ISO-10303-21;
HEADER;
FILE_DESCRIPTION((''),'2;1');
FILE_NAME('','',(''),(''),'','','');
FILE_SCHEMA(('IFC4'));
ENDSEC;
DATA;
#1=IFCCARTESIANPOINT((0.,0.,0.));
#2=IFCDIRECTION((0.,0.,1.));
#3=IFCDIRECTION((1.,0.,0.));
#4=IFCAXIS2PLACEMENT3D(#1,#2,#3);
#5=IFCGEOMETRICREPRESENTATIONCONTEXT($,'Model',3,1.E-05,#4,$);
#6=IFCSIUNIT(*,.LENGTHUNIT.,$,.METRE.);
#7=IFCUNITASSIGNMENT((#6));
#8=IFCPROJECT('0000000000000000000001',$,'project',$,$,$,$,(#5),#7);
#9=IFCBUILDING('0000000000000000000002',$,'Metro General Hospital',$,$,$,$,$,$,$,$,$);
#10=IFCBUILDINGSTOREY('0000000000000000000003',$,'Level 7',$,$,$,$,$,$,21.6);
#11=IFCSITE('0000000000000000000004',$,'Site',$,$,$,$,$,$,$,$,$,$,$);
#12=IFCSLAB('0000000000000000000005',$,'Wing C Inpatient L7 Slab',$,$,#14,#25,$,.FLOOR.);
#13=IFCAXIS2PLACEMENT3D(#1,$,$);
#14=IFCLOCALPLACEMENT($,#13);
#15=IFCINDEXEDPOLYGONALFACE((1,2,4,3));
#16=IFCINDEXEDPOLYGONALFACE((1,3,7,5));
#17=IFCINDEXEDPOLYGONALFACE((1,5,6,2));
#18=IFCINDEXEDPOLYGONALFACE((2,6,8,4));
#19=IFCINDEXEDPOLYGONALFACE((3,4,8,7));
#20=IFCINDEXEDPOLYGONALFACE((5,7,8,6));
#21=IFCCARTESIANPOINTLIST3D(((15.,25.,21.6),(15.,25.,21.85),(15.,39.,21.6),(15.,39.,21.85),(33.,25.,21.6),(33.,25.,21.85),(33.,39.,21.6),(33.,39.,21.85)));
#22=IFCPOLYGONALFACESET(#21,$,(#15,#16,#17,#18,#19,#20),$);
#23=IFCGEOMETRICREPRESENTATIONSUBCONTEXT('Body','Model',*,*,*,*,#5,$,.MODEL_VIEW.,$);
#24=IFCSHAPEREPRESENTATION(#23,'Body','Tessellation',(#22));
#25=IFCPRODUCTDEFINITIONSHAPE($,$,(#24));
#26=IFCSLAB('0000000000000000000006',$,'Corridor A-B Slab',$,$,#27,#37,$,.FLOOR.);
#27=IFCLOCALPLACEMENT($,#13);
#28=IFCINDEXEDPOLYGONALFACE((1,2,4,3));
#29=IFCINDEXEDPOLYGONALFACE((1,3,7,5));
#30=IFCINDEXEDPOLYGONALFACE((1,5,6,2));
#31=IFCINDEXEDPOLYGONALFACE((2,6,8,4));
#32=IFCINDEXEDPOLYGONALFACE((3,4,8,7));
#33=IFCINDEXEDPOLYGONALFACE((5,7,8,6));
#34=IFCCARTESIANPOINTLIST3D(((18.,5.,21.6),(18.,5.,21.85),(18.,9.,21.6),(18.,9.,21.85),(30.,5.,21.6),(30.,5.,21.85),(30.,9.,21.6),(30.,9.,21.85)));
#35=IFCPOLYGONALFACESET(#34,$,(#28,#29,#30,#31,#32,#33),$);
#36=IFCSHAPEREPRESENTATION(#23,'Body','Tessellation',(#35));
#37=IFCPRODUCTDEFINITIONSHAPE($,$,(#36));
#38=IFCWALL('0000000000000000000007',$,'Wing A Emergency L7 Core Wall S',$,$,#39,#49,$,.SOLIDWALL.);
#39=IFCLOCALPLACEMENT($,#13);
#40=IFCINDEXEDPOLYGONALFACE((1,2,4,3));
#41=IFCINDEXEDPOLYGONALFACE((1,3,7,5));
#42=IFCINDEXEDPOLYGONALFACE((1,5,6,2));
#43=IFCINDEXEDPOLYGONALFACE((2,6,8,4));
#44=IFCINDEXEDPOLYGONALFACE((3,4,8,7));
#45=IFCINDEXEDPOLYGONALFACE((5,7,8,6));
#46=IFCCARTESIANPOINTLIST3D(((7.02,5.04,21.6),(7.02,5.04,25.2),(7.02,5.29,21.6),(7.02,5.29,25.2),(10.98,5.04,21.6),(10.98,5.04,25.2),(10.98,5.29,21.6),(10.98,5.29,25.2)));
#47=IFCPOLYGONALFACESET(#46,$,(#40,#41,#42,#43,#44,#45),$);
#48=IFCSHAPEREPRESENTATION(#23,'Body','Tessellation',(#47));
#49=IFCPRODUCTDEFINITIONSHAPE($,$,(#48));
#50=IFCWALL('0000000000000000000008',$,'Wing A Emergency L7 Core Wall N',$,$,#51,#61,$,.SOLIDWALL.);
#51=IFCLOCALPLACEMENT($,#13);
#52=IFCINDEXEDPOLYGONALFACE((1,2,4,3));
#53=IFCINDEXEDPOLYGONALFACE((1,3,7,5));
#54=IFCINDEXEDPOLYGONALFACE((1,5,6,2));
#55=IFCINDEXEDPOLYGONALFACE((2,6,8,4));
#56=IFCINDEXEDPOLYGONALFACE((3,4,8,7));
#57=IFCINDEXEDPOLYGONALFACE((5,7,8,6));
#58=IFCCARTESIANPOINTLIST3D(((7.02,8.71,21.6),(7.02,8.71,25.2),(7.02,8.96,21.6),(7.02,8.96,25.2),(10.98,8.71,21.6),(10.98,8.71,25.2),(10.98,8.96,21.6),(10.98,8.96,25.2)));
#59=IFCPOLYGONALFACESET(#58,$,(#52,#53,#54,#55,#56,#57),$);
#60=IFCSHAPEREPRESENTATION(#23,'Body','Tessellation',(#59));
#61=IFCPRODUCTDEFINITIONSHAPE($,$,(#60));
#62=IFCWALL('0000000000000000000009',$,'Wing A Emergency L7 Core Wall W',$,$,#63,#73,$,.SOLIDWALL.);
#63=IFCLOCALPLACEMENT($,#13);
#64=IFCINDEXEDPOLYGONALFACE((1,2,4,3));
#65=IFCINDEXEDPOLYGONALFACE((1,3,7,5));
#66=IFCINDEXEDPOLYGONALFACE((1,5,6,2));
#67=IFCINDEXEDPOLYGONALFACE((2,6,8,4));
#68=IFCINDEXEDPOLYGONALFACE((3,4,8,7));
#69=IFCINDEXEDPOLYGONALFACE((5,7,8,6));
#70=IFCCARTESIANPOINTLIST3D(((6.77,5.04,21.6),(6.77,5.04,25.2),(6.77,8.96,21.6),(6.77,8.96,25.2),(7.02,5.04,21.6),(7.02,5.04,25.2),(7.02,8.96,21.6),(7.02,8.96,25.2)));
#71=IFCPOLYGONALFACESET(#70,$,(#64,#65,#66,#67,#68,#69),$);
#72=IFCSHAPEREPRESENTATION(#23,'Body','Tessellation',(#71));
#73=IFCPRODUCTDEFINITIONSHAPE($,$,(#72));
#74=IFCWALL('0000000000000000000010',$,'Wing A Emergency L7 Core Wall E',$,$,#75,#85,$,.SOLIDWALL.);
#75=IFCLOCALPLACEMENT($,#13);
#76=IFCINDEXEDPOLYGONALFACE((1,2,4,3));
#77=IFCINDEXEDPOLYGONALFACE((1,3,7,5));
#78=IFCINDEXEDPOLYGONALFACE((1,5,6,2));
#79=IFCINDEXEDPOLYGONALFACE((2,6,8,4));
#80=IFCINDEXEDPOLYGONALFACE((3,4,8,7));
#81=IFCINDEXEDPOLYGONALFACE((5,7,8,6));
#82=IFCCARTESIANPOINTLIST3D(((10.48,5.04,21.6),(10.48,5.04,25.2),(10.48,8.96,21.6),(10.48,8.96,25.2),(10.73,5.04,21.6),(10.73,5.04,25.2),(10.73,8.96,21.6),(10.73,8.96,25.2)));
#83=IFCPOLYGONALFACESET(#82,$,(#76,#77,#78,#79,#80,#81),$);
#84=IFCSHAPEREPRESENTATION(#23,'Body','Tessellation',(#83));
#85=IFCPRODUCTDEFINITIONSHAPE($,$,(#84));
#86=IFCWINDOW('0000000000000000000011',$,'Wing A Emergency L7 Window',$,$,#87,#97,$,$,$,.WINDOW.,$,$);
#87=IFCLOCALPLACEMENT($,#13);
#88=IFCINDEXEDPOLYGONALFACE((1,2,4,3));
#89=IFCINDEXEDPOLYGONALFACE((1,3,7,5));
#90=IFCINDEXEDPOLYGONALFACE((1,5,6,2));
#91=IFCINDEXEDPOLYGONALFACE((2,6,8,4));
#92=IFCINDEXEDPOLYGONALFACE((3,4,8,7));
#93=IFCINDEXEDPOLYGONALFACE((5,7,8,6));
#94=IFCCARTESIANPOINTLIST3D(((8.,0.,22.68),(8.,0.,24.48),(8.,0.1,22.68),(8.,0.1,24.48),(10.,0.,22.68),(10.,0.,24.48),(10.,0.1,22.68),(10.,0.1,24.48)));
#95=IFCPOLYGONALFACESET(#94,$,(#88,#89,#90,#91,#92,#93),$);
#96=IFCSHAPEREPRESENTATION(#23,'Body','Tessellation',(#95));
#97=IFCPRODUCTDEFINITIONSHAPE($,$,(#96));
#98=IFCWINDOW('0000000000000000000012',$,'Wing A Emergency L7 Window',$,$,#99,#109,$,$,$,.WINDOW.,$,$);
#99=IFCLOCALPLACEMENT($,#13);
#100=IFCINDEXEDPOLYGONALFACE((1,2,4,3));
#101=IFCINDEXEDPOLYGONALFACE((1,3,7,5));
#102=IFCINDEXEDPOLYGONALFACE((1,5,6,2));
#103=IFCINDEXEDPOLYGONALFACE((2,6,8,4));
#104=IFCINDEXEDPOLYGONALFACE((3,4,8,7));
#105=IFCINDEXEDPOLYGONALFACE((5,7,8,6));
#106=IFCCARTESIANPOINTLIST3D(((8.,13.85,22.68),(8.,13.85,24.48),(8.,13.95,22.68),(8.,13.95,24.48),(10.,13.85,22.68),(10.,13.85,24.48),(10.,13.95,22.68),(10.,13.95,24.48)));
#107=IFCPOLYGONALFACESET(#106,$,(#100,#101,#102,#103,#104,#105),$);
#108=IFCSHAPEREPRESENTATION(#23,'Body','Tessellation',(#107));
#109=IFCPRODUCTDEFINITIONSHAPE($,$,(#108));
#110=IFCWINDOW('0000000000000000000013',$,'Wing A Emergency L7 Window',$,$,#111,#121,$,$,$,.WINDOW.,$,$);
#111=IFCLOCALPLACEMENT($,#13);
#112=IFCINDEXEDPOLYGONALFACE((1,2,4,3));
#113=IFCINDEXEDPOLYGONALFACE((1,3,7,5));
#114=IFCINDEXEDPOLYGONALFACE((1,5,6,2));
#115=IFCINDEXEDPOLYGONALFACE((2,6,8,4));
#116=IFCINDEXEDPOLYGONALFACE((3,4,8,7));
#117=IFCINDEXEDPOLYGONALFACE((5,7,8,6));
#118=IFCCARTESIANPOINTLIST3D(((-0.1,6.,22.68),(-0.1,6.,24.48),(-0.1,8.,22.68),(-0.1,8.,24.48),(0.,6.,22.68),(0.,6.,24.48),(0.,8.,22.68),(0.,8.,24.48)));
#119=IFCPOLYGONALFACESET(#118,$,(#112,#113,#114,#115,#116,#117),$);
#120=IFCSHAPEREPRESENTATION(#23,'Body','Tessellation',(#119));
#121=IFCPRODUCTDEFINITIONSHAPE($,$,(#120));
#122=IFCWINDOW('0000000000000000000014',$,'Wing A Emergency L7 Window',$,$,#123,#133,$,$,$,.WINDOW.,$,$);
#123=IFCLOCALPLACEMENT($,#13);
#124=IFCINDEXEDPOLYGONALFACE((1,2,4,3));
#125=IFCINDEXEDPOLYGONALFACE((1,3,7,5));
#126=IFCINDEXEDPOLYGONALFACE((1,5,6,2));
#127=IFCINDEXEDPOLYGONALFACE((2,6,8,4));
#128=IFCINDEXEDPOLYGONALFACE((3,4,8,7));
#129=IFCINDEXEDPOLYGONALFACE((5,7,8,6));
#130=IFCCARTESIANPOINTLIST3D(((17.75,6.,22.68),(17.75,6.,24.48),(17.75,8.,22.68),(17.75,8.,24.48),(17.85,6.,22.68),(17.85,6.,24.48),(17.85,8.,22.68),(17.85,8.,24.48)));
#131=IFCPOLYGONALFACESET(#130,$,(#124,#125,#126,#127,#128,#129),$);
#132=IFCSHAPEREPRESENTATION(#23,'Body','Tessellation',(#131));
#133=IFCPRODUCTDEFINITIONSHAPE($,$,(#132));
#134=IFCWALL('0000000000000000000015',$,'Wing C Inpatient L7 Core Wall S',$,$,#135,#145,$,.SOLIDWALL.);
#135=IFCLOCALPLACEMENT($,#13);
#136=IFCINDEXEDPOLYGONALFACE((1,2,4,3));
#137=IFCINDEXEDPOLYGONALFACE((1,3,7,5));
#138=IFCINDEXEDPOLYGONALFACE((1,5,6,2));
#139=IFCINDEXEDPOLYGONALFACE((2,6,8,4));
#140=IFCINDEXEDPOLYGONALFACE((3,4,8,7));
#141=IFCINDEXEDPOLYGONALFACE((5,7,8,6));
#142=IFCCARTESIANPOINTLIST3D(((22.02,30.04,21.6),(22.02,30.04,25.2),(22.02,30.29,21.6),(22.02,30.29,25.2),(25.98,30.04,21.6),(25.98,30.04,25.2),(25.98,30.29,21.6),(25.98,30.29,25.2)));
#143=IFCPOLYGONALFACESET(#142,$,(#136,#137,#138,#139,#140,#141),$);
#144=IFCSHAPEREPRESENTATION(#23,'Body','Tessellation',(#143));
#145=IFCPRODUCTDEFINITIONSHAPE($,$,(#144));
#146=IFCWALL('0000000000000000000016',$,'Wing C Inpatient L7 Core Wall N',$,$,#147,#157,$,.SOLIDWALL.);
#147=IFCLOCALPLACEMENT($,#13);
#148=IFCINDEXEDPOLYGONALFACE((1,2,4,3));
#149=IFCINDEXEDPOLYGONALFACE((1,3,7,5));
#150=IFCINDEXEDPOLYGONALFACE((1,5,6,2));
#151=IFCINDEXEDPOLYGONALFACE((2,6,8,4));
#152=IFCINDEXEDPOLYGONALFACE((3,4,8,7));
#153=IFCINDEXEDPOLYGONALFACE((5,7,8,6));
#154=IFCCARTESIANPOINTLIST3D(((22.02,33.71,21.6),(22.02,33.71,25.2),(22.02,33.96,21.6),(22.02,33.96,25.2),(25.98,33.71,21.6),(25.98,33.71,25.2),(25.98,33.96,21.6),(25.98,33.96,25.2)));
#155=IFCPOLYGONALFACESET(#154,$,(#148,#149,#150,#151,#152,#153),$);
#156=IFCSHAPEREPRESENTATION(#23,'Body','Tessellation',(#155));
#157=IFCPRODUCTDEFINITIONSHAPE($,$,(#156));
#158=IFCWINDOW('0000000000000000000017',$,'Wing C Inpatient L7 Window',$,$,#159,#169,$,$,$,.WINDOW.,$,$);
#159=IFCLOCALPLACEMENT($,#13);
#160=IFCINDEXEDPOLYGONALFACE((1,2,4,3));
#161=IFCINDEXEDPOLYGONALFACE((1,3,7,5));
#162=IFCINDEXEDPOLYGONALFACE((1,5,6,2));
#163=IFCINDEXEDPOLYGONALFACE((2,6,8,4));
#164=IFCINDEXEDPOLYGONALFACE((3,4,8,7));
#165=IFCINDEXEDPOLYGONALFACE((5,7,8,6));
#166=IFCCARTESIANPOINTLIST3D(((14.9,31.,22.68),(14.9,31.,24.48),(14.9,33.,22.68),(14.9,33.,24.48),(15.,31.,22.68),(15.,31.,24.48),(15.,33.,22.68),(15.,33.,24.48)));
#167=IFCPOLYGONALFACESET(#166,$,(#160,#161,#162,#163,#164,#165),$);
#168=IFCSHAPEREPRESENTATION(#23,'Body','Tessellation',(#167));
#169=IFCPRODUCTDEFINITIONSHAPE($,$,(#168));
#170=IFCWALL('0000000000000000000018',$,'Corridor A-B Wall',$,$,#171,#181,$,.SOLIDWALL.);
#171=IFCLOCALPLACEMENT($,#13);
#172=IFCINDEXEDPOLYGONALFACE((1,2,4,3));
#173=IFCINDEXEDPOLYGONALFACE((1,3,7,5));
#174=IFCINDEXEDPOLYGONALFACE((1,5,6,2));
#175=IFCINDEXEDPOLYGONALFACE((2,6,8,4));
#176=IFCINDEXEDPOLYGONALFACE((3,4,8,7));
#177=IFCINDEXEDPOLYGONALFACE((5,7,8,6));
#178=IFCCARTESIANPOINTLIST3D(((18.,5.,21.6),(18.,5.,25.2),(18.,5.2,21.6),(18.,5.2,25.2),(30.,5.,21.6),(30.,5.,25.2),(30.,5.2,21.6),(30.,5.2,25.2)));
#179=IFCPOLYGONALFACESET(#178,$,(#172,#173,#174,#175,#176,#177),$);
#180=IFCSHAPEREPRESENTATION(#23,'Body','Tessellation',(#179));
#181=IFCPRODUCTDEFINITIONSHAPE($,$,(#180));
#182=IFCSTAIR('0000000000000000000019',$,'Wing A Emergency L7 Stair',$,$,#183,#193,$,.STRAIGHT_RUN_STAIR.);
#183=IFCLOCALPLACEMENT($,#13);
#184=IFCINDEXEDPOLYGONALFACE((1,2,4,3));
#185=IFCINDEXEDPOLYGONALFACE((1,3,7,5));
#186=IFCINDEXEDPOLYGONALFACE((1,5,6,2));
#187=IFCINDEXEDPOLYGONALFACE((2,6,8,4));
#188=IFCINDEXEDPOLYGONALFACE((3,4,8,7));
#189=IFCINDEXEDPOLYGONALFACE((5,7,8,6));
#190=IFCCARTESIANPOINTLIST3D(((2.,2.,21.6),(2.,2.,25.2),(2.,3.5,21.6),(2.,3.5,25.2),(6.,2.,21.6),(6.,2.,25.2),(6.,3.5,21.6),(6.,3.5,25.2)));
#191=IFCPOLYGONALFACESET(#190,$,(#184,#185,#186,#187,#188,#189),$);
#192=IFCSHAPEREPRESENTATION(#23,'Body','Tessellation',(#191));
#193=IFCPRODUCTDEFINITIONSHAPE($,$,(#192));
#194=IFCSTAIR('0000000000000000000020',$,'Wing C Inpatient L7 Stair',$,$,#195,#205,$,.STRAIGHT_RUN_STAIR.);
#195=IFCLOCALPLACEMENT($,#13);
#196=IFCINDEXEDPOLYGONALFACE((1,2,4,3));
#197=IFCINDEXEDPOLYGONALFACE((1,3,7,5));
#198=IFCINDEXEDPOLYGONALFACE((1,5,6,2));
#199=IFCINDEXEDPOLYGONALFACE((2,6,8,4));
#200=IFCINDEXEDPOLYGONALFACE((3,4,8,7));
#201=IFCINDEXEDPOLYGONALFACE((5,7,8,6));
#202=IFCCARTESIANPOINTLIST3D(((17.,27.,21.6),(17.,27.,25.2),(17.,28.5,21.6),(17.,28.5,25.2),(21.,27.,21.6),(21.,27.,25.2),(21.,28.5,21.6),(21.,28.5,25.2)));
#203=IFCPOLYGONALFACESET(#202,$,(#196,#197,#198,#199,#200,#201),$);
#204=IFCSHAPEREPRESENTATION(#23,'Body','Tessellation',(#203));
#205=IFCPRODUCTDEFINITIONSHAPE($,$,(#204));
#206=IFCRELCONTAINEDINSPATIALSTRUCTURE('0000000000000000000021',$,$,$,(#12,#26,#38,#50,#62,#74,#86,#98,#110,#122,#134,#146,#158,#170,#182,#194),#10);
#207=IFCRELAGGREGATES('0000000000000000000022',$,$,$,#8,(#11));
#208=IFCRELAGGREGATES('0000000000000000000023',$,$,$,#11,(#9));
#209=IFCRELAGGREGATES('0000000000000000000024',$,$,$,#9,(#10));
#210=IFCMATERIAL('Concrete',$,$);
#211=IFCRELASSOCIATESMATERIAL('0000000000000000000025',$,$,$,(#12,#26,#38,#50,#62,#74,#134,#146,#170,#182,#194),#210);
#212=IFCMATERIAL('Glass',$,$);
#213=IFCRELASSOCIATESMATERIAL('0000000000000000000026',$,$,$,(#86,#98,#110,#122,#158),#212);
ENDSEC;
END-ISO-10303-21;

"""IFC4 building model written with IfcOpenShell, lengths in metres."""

from ifc_helpers import new_model, si_unit, frame, origin_with_axes, place, context, subcontext, project, spatial, line, indexed_curve, outline, extrude, material, element, save


model = new_model("IFC4")

# Units and contexts
model_context = context("Model", 3, precision=1e-05, world=origin_with_axes())
body_context = subcontext(model_context, "Body", "Model", "MODEL_VIEW")
ifc_project = project(units=[si_unit("LENGTHUNIT", "METRE")], contexts=[model_context])

# Site, building, storey
site = spatial("IfcSite", under=ifc_project, Name="Site")
building = spatial("IfcBuilding", under=site, Name="Metro General Hospital")
storey = spatial("IfcBuildingStorey", under=building, Name="Level 7", Elevation=21.6)

# Slabs
ifc_material_1 = material(Name="Concrete")
for number, where, z_axis, x_axis, name in (
    (1, (15.0, 25.0, 21.6), (0.0, 0.0, 1.0), (1.0, 0.0, 0.0), "Wing C Inpatient L7 Slab"),
):
    element("IfcSlab", number, at=place(None, frame(where, z_axis=z_axis, x_axis=x_axis)), inside=storey, material=ifc_material_1, Name=name, PredefinedType="FLOOR", context=body_context, shape_type="SweptSolid", body=[
        extrude(outline(indexed_curve([(0.0, 0.0), (18.0, 0.0), (18.0, 14.0), (0.0, 14.0)], segments=[line(1, 2, 3, 4, 1)])), origin_with_axes(), (0.0, 0.0, 1.0), 0.25),
    ])
slab_placement = place(None, frame((18.0, 5.0, 21.6), z_axis=(0.0, 0.0, 1.0), x_axis=(1.0, 0.0, 0.0)))
element("IfcSlab", 2, at=slab_placement, inside=storey, material=ifc_material_1, Name="Corridor A-B Slab", PredefinedType="FLOOR", context=body_context, shape_type="SweptSolid", body=[
    extrude(outline(indexed_curve([(0.0, 0.0), (12.0, 0.0), (12.0, 4.0), (0.0, 4.0)], segments=[line(1, 2, 3, 4, 1)])), origin_with_axes(), (0.0, 0.0, 1.0), 0.25),
])

# Walls
for number, where, z_axis, x_axis, name in (
    (3, (7.02, 5.04, 21.6), (0.0, 0.0, 1.0), (1.0, 0.0, 0.0), "Wing A Emergency L7 Core Wall S"),
    (4, (7.02, 8.71, 21.6), (0.0, 0.0, 1.0), (1.0, 0.0, 0.0), "Wing A Emergency L7 Core Wall N"),
):
    element("IfcWall", number, at=place(None, frame(where, z_axis=z_axis, x_axis=x_axis)), inside=storey, material=ifc_material_1, Name=name, PredefinedType="SOLIDWALL", context=body_context, shape_type="SweptSolid", body=[
        extrude(outline(indexed_curve([(0.0, 0.0), (3.96, 0.0), (3.96, 0.25), (0.0, 0.25)], segments=[line(1, 2, 3, 4, 1)])), origin_with_axes(), (0.0, 0.0, 1.0), 3.6),
    ])
for number, where, z_axis, x_axis, name in (
    (5, (7.02, 5.04, 21.6), (0.0, 0.0, 1.0), (0.0, 1.0, 0.0), "Wing A Emergency L7 Core Wall W"),
    (6, (10.73, 5.04, 21.6), (0.0, 0.0, 1.0), (0.0, 1.0, 0.0), "Wing A Emergency L7 Core Wall E"),
):
    element("IfcWall", number, at=place(None, frame(where, z_axis=z_axis, x_axis=x_axis)), inside=storey, material=ifc_material_1, Name=name, PredefinedType="SOLIDWALL", context=body_context, shape_type="SweptSolid", body=[
        extrude(outline(indexed_curve([(0.0, 0.0), (3.92, 0.0), (3.92, 0.25), (0.0, 0.25)], segments=[line(1, 2, 3, 4, 1)])), origin_with_axes(), (0.0, 0.0, 1.0), 3.6),
    ])

# Windows
ifc_material_2 = material(Name="Glass")
for number, where, z_axis, x_axis, name in (
    (7, (8.0, 0.0, 22.68), (0.0, 0.0, 1.0), (1.0, 0.0, 0.0), "Wing A Emergency L7 Window"),
    (8, (8.0, 13.85, 22.68), (0.0, 0.0, 1.0), (1.0, 0.0, 0.0), "Wing A Emergency L7 Window"),
    (9, (0.0, 6.0, 22.68), (0.0, 0.0, 1.0), (0.0, 1.0, 0.0), "Wing A Emergency L7 Window"),
    (10, (17.85, 6.0, 22.68), (0.0, 0.0, 1.0), (0.0, 1.0, 0.0), "Wing A Emergency L7 Window"),
):
    element("IfcWindow", number, at=place(None, frame(where, z_axis=z_axis, x_axis=x_axis)), inside=storey, material=ifc_material_2, Name=name, PredefinedType="WINDOW", context=body_context, shape_type="SweptSolid", body=[
        extrude(outline(indexed_curve([(0.0, 0.0), (2.0, 0.0), (2.0, 0.1), (0.0, 0.1)], segments=[line(1, 2, 3, 4, 1)])), origin_with_axes(), (0.0, 0.0, 1.0), 1.8),
    ])

# Walls
for number, where, z_axis, x_axis, name in (
    (11, (22.02, 30.04, 21.6), (0.0, 0.0, 1.0), (1.0, 0.0, 0.0), "Wing C Inpatient L7 Core Wall S"),
    (12, (22.02, 33.71, 21.6), (0.0, 0.0, 1.0), (1.0, 0.0, 0.0), "Wing C Inpatient L7 Core Wall N"),
):
    element("IfcWall", number, at=place(None, frame(where, z_axis=z_axis, x_axis=x_axis)), inside=storey, material=ifc_material_1, Name=name, PredefinedType="SOLIDWALL", context=body_context, shape_type="SweptSolid", body=[
        extrude(outline(indexed_curve([(0.0, 0.0), (3.96, 0.0), (3.96, 0.25), (0.0, 0.25)], segments=[line(1, 2, 3, 4, 1)])), origin_with_axes(), (0.0, 0.0, 1.0), 3.6),
    ])

# Window
window_placement = place(None, frame((15.0, 31.0, 22.68), z_axis=(0.0, 0.0, 1.0), x_axis=(0.0, 1.0, 0.0)))
element("IfcWindow", 13, at=window_placement, inside=storey, material=ifc_material_2, Name="Wing C Inpatient L7 Window", PredefinedType="WINDOW", context=body_context, shape_type="SweptSolid", body=[
    extrude(outline(indexed_curve([(0.0, 0.0), (2.0, 0.0), (2.0, 0.1), (0.0, 0.1)], segments=[line(1, 2, 3, 4, 1)])), origin_with_axes(), (0.0, 0.0, 1.0), 1.8),
])

# Wall
wall_placement = place(None, frame((18.0, 5.0, 21.6), z_axis=(0.0, 0.0, 1.0), x_axis=(1.0, 0.0, 0.0)))
element("IfcWall", 14, at=wall_placement, inside=storey, material=ifc_material_1, Name="Corridor A-B Wall", PredefinedType="SOLIDWALL", context=body_context, shape_type="SweptSolid", body=[
    extrude(outline(indexed_curve([(0.0, 0.0), (12.0, 0.0), (12.0, 0.2), (0.0, 0.2)], segments=[line(1, 2, 3, 4, 1)])), origin_with_axes(), (0.0, 0.0, 1.0), 3.6),
])

# Stairs
for number, where, z_axis, x_axis, name in (
    (15, (2.0, 2.0, 21.6), (0.0, 0.0, 1.0), (1.0, 0.0, 0.0), "Wing A Emergency L7 Stair"),
    (16, (17.0, 27.0, 21.6), (0.0, 0.0, 1.0), (1.0, 0.0, 0.0), "Wing C Inpatient L7 Stair"),
):
    element("IfcStair", number, at=place(None, frame(where, z_axis=z_axis, x_axis=x_axis)), inside=storey, material=ifc_material_1, Name=name, PredefinedType="STRAIGHT_RUN_STAIR", context=body_context, shape_type="SweptSolid", body=[
        extrude(outline(indexed_curve([(0.0, 0.0), (4.0, 0.0), (4.0, 1.5), (0.0, 1.5)], segments=[line(1, 2, 3, 4, 1)])), origin_with_axes(), (0.0, 0.0, 1.0), 3.6),
    ])

save(model, "model.ifc")
